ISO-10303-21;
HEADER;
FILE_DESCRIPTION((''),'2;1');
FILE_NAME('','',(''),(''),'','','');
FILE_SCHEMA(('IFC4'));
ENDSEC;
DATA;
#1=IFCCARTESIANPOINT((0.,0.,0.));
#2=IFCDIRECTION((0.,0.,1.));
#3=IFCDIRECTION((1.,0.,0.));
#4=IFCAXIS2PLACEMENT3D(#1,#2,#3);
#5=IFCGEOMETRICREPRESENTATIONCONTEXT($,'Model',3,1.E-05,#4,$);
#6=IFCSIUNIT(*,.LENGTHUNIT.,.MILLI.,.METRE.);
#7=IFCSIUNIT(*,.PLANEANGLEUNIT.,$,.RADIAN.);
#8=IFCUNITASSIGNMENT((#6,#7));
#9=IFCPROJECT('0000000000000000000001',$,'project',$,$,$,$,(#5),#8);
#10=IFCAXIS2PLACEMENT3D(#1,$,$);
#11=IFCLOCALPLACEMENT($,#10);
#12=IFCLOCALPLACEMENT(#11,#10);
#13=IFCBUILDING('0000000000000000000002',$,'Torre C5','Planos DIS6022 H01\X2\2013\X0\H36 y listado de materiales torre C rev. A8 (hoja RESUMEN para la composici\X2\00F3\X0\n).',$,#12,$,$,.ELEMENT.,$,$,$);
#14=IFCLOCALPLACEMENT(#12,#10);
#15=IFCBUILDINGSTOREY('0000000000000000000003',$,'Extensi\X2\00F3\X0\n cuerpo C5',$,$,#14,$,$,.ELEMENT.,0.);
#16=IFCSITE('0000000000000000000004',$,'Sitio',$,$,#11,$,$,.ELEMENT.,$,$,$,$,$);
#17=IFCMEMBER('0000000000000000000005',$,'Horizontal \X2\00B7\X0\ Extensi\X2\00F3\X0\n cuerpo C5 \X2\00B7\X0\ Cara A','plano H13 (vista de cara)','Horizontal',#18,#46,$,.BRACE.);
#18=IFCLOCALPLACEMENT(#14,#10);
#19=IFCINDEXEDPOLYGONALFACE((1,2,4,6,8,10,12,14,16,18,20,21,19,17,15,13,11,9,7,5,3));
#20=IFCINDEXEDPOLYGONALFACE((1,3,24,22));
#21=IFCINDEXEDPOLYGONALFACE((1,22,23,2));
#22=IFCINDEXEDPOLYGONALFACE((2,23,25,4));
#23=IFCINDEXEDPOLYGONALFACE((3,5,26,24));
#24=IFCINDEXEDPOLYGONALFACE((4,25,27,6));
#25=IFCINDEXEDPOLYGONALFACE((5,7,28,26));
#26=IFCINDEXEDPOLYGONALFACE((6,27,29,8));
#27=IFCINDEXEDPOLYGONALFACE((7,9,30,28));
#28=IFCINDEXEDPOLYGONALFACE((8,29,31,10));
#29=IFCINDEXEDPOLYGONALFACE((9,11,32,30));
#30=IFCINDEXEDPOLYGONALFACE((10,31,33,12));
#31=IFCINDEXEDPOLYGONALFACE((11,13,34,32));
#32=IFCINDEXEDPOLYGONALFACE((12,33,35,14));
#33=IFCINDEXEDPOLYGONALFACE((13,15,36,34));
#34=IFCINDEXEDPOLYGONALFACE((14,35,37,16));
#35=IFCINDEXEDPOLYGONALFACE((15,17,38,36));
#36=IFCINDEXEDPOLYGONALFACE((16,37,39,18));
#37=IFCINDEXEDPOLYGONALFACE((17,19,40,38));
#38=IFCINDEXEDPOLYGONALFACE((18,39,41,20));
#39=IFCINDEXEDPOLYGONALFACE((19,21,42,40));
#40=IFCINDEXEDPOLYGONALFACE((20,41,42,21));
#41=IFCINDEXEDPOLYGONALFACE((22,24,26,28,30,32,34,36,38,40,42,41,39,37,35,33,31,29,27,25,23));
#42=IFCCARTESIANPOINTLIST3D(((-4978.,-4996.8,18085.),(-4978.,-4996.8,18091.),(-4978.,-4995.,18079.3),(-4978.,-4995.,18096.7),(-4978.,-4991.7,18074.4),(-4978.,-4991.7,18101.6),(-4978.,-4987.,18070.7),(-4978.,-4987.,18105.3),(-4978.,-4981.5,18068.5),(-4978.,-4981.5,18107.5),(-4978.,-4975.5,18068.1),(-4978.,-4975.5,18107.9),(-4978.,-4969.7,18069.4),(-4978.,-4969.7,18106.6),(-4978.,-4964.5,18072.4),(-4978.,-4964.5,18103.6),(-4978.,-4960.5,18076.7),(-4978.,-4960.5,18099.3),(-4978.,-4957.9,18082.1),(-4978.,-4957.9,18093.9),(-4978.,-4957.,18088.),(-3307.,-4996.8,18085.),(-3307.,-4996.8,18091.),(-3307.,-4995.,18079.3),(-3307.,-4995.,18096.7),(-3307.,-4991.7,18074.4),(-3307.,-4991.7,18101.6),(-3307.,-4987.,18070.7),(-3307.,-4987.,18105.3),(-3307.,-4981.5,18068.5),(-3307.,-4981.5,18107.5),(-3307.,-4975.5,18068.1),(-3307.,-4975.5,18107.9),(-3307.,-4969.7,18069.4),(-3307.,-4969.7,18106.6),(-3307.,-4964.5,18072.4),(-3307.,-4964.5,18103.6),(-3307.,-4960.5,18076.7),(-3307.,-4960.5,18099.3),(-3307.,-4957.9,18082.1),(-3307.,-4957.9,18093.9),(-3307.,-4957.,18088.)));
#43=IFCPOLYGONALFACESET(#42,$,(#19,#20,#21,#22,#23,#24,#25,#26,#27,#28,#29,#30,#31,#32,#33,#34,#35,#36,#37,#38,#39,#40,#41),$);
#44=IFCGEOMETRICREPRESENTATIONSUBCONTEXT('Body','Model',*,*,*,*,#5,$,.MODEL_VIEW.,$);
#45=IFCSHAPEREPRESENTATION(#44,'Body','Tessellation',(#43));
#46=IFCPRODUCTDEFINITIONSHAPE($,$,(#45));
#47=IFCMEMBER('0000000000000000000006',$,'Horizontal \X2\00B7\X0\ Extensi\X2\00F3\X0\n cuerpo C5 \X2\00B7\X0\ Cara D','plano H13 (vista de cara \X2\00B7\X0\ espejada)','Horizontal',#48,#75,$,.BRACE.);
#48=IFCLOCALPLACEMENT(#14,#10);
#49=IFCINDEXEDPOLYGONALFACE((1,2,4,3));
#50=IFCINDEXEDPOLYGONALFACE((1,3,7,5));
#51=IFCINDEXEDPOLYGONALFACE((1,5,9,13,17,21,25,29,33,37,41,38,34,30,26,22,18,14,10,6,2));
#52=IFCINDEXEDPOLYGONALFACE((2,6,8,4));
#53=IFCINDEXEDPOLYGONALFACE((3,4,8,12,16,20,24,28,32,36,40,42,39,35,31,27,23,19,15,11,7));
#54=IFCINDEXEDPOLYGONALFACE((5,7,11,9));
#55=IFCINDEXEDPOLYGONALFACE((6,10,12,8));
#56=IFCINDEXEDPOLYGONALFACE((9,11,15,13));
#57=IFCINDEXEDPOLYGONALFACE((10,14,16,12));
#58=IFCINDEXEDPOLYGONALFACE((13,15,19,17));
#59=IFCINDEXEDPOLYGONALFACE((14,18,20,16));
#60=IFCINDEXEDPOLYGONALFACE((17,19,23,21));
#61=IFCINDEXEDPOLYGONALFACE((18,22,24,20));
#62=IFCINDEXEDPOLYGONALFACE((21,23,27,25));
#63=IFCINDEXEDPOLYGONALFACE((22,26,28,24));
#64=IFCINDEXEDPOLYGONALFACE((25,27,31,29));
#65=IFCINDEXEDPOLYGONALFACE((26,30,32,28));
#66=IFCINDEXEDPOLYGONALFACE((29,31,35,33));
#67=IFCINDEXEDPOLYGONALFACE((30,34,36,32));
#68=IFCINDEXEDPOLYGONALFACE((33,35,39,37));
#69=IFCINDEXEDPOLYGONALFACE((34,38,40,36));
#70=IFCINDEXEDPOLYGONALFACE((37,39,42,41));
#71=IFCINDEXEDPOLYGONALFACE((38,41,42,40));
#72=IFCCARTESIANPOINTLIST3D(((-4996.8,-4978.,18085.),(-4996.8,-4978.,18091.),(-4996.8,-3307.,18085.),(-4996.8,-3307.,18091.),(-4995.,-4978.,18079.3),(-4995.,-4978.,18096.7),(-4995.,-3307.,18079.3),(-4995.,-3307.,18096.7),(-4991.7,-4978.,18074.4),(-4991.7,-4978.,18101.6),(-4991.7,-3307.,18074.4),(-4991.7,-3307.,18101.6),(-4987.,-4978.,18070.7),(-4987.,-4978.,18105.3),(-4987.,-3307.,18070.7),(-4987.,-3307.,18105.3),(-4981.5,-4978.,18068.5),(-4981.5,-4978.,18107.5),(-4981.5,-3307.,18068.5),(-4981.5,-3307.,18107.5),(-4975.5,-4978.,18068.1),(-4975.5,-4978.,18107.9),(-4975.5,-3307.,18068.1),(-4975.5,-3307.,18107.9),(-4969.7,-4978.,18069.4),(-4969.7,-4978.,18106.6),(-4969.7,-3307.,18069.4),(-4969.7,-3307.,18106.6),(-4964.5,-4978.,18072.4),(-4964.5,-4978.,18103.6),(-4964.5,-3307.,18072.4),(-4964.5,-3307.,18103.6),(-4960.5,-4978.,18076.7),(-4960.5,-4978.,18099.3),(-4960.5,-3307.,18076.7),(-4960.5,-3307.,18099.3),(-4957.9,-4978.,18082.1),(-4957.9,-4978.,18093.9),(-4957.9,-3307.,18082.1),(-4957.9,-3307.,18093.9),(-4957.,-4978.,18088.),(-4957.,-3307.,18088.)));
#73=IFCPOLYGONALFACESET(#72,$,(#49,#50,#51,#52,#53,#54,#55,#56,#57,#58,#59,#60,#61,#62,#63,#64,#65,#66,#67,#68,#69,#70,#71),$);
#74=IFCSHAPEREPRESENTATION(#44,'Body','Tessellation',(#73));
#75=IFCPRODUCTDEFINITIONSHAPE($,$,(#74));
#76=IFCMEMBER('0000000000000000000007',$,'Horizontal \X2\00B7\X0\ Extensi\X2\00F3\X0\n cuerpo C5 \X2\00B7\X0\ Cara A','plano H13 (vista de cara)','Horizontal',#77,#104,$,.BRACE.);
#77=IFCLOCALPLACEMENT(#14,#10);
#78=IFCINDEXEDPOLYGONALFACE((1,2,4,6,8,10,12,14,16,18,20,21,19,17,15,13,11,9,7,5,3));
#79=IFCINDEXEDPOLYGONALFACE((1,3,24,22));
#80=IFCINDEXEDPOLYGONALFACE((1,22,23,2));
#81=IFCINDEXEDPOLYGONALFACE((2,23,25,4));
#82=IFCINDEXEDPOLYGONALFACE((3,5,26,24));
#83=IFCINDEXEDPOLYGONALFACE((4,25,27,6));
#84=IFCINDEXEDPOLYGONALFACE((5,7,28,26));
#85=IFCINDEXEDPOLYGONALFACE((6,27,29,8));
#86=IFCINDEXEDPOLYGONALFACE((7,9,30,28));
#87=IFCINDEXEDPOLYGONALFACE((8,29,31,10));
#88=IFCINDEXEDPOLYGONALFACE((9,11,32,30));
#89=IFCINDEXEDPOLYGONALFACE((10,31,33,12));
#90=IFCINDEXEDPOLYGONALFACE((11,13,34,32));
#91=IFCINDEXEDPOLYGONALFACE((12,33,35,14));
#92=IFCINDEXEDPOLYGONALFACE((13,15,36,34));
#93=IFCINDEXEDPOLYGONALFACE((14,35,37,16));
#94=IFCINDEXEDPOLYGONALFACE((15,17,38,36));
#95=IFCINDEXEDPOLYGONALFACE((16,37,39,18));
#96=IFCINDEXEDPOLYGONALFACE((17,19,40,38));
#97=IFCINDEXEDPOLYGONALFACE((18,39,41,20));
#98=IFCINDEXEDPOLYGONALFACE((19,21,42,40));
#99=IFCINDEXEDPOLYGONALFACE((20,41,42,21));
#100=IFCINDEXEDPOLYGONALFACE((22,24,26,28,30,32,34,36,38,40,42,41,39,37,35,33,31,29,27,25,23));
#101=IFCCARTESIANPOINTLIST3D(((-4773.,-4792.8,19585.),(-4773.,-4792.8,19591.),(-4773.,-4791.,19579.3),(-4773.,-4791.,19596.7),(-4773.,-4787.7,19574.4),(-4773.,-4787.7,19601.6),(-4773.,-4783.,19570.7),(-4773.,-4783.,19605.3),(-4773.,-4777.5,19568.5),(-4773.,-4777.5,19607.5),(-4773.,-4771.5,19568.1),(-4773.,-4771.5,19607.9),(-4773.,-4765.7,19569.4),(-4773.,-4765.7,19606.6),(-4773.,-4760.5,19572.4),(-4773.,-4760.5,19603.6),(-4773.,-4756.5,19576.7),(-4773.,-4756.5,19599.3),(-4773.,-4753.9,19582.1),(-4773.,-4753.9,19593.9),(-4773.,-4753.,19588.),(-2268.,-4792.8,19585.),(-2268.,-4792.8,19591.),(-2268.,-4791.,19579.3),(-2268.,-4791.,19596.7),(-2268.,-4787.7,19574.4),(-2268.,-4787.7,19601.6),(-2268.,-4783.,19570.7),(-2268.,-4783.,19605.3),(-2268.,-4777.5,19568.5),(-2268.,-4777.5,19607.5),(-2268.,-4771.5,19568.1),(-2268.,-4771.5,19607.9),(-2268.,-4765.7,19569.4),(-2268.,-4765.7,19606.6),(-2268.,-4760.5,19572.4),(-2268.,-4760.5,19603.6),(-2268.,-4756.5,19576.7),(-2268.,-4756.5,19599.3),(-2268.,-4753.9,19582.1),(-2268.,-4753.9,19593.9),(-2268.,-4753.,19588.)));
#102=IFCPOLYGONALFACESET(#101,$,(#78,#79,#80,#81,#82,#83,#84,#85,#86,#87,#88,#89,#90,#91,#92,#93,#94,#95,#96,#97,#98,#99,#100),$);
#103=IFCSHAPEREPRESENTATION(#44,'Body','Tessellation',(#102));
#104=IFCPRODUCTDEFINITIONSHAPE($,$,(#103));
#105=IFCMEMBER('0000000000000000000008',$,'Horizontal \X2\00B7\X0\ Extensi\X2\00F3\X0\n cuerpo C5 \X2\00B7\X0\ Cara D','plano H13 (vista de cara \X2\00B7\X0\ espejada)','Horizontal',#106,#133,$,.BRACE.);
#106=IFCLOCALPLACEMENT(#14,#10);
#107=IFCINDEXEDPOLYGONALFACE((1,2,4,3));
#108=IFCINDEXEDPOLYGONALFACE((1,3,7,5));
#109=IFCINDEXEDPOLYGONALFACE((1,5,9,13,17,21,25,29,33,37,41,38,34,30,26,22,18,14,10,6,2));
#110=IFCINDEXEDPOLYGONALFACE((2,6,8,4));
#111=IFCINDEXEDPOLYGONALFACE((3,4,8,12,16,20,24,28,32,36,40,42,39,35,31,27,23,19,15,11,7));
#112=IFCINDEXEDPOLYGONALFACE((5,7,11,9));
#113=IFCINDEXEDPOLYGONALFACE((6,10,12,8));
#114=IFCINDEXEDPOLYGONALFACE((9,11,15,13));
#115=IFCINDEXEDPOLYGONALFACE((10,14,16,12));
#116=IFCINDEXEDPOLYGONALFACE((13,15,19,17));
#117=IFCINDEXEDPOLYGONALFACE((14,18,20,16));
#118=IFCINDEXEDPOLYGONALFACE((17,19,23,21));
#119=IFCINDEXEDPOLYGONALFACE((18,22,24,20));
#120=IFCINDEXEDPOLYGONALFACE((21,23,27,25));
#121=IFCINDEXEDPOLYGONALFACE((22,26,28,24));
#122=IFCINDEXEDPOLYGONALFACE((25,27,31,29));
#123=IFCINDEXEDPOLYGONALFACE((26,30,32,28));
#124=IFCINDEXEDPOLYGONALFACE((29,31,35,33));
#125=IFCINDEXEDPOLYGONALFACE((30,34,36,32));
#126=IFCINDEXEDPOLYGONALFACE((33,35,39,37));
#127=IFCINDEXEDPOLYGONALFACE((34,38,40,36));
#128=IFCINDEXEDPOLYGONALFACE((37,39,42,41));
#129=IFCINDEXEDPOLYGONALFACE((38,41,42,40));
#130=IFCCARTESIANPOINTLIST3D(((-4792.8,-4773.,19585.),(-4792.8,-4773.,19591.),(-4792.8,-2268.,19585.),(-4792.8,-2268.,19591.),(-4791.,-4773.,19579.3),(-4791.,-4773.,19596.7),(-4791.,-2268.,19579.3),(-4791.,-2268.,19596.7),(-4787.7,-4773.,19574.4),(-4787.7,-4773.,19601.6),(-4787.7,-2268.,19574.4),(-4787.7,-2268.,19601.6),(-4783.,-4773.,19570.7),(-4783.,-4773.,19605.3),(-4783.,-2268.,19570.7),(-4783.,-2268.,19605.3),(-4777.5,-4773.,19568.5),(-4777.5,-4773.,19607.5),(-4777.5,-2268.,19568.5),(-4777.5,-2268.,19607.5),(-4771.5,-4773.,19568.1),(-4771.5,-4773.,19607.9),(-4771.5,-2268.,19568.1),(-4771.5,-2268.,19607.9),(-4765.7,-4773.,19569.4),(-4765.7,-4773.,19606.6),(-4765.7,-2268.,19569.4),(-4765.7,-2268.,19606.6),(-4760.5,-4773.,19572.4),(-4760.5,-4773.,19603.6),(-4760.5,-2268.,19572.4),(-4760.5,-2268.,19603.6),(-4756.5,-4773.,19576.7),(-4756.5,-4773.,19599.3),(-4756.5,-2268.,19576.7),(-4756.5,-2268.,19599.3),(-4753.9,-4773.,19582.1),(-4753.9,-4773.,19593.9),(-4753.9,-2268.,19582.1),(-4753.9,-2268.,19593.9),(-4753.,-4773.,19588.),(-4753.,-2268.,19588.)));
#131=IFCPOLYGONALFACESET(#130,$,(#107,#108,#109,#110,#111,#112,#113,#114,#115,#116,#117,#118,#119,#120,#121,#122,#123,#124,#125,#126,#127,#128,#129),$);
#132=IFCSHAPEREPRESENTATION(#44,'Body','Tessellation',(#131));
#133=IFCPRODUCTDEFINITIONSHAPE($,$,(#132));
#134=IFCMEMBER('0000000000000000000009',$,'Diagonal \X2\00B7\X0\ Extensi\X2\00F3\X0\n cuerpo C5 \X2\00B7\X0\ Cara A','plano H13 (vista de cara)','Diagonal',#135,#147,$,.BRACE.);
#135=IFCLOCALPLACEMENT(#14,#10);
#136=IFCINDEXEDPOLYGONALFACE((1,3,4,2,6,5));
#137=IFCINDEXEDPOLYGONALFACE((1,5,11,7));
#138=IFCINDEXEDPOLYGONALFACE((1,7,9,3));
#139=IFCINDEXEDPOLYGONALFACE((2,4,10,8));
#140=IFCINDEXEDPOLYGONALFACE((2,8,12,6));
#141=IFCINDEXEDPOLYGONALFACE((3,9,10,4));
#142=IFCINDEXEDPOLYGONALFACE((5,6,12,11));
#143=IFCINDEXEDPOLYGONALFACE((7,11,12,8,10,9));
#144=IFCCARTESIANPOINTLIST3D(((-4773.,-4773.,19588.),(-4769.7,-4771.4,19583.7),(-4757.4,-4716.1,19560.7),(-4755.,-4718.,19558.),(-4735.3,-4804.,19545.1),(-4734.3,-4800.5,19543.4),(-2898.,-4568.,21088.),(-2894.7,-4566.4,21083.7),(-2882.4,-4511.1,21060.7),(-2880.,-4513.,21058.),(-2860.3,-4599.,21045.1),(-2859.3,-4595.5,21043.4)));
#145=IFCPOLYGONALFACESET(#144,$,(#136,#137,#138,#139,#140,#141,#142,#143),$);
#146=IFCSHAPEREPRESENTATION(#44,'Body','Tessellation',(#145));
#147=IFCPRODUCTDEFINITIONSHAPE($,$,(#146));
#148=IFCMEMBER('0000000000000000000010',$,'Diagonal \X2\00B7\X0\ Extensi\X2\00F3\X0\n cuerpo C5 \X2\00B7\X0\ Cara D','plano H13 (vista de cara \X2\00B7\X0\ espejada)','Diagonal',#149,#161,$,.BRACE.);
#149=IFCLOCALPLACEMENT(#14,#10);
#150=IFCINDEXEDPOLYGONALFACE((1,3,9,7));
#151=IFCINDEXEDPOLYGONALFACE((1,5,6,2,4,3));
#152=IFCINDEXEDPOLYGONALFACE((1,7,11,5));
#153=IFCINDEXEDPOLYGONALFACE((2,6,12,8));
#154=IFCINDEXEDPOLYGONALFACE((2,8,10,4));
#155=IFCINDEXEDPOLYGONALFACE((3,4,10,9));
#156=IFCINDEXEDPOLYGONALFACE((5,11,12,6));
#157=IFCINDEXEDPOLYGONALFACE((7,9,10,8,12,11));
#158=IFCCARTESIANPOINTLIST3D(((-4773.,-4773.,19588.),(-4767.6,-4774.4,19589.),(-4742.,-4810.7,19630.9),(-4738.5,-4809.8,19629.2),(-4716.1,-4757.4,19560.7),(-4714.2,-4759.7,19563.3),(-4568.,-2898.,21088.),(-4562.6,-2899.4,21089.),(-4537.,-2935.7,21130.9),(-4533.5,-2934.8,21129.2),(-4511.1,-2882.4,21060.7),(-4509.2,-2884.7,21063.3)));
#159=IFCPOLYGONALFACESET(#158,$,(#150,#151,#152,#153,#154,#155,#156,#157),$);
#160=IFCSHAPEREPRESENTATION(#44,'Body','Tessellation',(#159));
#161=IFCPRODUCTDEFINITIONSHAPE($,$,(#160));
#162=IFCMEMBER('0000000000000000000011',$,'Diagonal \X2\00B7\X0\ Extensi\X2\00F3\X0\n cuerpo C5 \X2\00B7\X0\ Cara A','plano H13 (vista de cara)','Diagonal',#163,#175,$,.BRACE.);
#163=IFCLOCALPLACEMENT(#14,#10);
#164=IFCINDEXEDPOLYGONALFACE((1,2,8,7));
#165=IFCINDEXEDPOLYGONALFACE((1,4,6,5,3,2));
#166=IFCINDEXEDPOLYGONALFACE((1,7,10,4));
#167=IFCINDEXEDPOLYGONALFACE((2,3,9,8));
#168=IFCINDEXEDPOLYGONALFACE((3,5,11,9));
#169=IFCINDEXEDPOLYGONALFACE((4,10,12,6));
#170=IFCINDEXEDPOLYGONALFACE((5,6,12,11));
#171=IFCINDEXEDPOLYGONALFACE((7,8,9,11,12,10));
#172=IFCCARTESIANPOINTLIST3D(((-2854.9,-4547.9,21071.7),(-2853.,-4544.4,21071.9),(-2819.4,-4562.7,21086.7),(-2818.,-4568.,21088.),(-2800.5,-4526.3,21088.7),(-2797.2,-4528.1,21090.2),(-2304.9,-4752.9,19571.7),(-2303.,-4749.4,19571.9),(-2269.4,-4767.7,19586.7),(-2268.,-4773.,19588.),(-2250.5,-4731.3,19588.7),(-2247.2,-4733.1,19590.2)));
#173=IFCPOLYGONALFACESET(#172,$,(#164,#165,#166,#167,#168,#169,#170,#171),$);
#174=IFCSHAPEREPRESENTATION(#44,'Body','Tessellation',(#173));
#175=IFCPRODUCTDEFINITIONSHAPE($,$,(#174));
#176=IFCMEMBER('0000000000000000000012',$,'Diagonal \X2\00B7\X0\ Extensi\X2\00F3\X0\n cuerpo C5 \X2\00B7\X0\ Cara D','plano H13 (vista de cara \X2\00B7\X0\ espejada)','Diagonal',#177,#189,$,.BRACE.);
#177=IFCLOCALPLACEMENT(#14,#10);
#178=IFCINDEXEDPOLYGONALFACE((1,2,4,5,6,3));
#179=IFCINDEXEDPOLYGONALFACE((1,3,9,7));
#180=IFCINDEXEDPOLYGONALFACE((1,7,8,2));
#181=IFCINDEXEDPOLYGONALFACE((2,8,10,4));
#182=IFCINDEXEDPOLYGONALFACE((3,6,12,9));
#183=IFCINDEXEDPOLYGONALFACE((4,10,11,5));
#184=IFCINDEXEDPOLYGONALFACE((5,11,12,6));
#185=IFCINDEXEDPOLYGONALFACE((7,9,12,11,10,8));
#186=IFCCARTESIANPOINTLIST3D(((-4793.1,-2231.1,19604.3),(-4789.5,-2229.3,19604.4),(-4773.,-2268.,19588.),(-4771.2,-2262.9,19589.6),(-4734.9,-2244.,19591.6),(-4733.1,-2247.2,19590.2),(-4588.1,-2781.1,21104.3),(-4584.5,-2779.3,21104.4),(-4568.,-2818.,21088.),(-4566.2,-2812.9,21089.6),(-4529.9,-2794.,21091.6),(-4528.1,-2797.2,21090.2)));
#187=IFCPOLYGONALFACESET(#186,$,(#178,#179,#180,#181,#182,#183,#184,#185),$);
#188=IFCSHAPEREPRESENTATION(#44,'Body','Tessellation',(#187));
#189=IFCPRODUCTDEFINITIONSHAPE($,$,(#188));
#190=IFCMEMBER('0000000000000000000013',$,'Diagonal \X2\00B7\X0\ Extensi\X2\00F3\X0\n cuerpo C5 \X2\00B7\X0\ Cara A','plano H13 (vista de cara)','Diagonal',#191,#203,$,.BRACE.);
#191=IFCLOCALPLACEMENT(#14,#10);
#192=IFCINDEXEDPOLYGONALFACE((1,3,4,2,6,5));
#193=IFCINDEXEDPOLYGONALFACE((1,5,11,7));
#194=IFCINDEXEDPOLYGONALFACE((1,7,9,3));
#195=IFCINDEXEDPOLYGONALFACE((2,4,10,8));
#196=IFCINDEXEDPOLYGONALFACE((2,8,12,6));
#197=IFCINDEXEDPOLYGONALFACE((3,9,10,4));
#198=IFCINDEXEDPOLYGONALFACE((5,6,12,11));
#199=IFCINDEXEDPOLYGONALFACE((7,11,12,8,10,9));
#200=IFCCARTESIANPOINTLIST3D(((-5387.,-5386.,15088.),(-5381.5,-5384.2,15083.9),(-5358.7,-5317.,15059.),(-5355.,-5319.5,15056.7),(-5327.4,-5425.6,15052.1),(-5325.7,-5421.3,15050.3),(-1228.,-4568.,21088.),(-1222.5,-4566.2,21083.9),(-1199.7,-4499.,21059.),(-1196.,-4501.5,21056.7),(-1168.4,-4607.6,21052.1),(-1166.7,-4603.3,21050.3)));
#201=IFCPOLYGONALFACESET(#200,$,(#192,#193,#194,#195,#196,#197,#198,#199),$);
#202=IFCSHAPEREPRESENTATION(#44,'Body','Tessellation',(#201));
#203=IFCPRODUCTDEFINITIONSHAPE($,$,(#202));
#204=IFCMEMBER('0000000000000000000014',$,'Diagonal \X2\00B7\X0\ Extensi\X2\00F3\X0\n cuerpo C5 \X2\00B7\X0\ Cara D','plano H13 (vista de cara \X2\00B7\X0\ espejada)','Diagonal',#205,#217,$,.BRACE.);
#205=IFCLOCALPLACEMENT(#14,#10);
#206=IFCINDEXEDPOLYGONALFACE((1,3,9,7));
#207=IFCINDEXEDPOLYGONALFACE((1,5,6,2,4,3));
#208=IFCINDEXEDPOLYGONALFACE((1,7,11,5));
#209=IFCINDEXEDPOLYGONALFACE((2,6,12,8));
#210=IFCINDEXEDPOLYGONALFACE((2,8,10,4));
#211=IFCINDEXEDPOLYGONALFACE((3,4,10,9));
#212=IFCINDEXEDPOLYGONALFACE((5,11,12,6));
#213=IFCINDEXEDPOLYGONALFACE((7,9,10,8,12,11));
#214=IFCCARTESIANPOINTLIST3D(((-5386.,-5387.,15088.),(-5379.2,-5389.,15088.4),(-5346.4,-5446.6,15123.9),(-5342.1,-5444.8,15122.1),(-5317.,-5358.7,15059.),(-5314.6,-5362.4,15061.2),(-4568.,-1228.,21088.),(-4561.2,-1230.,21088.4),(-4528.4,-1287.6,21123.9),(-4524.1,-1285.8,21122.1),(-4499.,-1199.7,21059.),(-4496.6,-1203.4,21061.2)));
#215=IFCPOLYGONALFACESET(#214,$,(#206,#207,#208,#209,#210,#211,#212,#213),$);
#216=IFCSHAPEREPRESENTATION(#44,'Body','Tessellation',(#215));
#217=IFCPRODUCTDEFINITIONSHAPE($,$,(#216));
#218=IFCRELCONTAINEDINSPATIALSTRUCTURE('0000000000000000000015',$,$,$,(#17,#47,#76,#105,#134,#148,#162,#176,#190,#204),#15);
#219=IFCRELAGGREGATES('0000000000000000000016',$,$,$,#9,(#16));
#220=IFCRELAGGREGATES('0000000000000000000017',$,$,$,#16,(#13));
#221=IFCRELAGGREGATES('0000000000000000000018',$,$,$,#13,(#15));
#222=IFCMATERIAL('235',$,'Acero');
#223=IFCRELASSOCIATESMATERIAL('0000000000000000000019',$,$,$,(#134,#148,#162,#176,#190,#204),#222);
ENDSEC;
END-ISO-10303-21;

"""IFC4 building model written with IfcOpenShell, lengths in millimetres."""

from ifc_helpers import new_model, si_unit, frame, frame_2d, origin, origin_with_axes, place, context, subcontext, project, spatial, circle, l_section, extrude, material, element, save


model = new_model("IFC4")

# Units and contexts
model_context = context("Model", 3, precision=1e-05, world=origin_with_axes())
body_context = subcontext(model_context, "Body", "Model", "MODEL_VIEW")
ifc_project = project(units=[si_unit("LENGTHUNIT", "METRE", prefix="MILLI"), si_unit("PLANEANGLEUNIT", "RADIAN")], contexts=[model_context])

# Site, building, storey
site_placement = place(None, origin())
site = spatial("IfcSite", under=ifc_project, at=site_placement, Name="Sitio", CompositionType="ELEMENT")
building_placement = place(site_placement, origin())
building = spatial("IfcBuilding", under=site, at=building_placement, Name="Torre C5", Description="Planos DIS6022 H01–H36 y listado de materiales torre C rev. A8 (hoja RESUMEN para la composición).", CompositionType="ELEMENT")
storey_placement = place(building_placement, origin())
storey = spatial("IfcBuildingStorey", under=building, at=storey_placement, Name="Extensión cuerpo C5", CompositionType="ELEMENT", Elevation=0.0)

# Members
ifc_material = material(Name="235", Category="Acero")
for number, where, z_axis, x_axis, name, description in (
    (1, (-3307.0, -4977.0, 18088.0), (-1.0, 0.0, 0.0), (0.0, 1.0, 0.0), "Horizontal · Extensión cuerpo C5 · Cara A", "plano H13 (vista de cara)"),
    (2, (-4977.0, -3307.0, 18088.0), (0.0, -1.0, 0.0), (1.0, 0.0, 0.0), "Horizontal · Extensión cuerpo C5 · Cara D", "plano H13 (vista de cara · espejada)"),
):
    element("IfcMember", number, at=place(storey_placement, frame(where, z_axis=z_axis, x_axis=x_axis)), inside=storey, Name=name, Description=description, ObjectType="Horizontal", PredefinedType="BRACE", context=body_context, shape_type="SweptSolid", body=[
        extrude(circle(Radius=20.0), None, (0.0, 0.0, 1.0), 1671.0),
    ])
for number, where, z_axis, x_axis, name, description in (
    (3, (-2268.0, -4773.0, 19588.0), (-1.0, 0.0, 0.0), (0.0, 1.0, 0.0), "Horizontal · Extensión cuerpo C5 · Cara A", "plano H13 (vista de cara)"),
    (4, (-4773.0, -2268.0, 19588.0), (0.0, -1.0, 0.0), (1.0, 0.0, 0.0), "Horizontal · Extensión cuerpo C5 · Cara D", "plano H13 (vista de cara · espejada)"),
):
    element("IfcMember", number, at=place(storey_placement, frame(where, z_axis=z_axis, x_axis=x_axis)), inside=storey, Name=name, Description=description, ObjectType="Horizontal", PredefinedType="BRACE", context=body_context, shape_type="SweptSolid", body=[
        extrude(circle(Radius=20.0), None, (0.0, 0.0, 1.0), 2505.0),
    ])
for number, where, z_axis, x_axis, name, description in (
    (5, (-2898.0, -4568.0, 21088.0), (-0.778038, -0.085066, -0.622431), (0.240484, 0.874992, -0.420187), "Diagonal · Extensión cuerpo C5 · Cara A", "plano H13 (vista de cara)"),
    (6, (-4568.0, -2898.0, 21088.0), (-0.085066, -0.778038, -0.622431), (0.874992, 0.240484, -0.420187), "Diagonal · Extensión cuerpo C5 · Cara D", "plano H13 (vista de cara · espejada)"),
):
    element("IfcMember", number, at=place(storey_placement, frame(where, z_axis=z_axis, x_axis=x_axis)), inside=storey, material=ifc_material, Name=name, Description=description, ObjectType="Diagonal", PredefinedType="BRACE", context=body_context, shape_type="SweptSolid", body=[
        extrude(l_section(Depth=65.0, Width=65.0, Thickness=4.0, at=frame_2d((32.5, 32.5))), None, (0.0, 0.0, 1.0), 2409.9),
    ])
for number, where, z_axis, x_axis, name, description in (
    (7, (-2268.0, -4773.0, 19588.0), (-0.341455, 0.12727, 0.931242), (0.461218, 0.885986, 0.048029), "Diagonal · Extensión cuerpo C5 · Cara A", "plano H13 (vista de cara)"),
    (8, (-4773.0, -2268.0, 19588.0), (0.12727, -0.341455, 0.931242), (0.885986, 0.461218, 0.048029), "Diagonal · Extensión cuerpo C5 · Cara D", "plano H13 (vista de cara · espejada)"),
):
    element("IfcMember", number, at=place(storey_placement, frame(where, z_axis=z_axis, x_axis=x_axis)), inside=storey, material=ifc_material, Name=name, Description=description, ObjectType="Diagonal", PredefinedType="BRACE", context=body_context, shape_type="SweptSolid", body=[
        extrude(l_section(Depth=45.0, Width=45.0, Thickness=4.0, at=frame_2d((22.5, 22.5))), None, (0.0, 0.0, 1.0), 1610.8),
    ])
for number, where, z_axis, x_axis, name, description in (
    (9, (-1228.0, -4568.0, 21088.0), (-0.566144, -0.11135, -0.816751), (0.354088, 0.86191, -0.362949), "Diagonal · Extensión cuerpo C5 · Cara A", "plano H13 (vista de cara)"),
    (10, (-4568.0, -1228.0, 21088.0), (-0.11135, -0.566144, -0.816751), (0.86191, 0.354088, -0.362949), "Diagonal · Extensión cuerpo C5 · Cara D", "plano H13 (vista de cara · espejada)"),
):
    element("IfcMember", number, at=place(storey_placement, frame(where, z_axis=z_axis, x_axis=x_axis)), inside=storey, material=ifc_material, Name=name, Description=description, ObjectType="Diagonal", PredefinedType="BRACE", context=body_context, shape_type="SweptSolid", body=[
        extrude(l_section(Depth=80.0, Width=80.0, Thickness=5.0, at=frame_2d((40.0, 40.0))), None, (0.0, 0.0, 1.0), 7346.2),
    ])

save(model, "model.ifc")
